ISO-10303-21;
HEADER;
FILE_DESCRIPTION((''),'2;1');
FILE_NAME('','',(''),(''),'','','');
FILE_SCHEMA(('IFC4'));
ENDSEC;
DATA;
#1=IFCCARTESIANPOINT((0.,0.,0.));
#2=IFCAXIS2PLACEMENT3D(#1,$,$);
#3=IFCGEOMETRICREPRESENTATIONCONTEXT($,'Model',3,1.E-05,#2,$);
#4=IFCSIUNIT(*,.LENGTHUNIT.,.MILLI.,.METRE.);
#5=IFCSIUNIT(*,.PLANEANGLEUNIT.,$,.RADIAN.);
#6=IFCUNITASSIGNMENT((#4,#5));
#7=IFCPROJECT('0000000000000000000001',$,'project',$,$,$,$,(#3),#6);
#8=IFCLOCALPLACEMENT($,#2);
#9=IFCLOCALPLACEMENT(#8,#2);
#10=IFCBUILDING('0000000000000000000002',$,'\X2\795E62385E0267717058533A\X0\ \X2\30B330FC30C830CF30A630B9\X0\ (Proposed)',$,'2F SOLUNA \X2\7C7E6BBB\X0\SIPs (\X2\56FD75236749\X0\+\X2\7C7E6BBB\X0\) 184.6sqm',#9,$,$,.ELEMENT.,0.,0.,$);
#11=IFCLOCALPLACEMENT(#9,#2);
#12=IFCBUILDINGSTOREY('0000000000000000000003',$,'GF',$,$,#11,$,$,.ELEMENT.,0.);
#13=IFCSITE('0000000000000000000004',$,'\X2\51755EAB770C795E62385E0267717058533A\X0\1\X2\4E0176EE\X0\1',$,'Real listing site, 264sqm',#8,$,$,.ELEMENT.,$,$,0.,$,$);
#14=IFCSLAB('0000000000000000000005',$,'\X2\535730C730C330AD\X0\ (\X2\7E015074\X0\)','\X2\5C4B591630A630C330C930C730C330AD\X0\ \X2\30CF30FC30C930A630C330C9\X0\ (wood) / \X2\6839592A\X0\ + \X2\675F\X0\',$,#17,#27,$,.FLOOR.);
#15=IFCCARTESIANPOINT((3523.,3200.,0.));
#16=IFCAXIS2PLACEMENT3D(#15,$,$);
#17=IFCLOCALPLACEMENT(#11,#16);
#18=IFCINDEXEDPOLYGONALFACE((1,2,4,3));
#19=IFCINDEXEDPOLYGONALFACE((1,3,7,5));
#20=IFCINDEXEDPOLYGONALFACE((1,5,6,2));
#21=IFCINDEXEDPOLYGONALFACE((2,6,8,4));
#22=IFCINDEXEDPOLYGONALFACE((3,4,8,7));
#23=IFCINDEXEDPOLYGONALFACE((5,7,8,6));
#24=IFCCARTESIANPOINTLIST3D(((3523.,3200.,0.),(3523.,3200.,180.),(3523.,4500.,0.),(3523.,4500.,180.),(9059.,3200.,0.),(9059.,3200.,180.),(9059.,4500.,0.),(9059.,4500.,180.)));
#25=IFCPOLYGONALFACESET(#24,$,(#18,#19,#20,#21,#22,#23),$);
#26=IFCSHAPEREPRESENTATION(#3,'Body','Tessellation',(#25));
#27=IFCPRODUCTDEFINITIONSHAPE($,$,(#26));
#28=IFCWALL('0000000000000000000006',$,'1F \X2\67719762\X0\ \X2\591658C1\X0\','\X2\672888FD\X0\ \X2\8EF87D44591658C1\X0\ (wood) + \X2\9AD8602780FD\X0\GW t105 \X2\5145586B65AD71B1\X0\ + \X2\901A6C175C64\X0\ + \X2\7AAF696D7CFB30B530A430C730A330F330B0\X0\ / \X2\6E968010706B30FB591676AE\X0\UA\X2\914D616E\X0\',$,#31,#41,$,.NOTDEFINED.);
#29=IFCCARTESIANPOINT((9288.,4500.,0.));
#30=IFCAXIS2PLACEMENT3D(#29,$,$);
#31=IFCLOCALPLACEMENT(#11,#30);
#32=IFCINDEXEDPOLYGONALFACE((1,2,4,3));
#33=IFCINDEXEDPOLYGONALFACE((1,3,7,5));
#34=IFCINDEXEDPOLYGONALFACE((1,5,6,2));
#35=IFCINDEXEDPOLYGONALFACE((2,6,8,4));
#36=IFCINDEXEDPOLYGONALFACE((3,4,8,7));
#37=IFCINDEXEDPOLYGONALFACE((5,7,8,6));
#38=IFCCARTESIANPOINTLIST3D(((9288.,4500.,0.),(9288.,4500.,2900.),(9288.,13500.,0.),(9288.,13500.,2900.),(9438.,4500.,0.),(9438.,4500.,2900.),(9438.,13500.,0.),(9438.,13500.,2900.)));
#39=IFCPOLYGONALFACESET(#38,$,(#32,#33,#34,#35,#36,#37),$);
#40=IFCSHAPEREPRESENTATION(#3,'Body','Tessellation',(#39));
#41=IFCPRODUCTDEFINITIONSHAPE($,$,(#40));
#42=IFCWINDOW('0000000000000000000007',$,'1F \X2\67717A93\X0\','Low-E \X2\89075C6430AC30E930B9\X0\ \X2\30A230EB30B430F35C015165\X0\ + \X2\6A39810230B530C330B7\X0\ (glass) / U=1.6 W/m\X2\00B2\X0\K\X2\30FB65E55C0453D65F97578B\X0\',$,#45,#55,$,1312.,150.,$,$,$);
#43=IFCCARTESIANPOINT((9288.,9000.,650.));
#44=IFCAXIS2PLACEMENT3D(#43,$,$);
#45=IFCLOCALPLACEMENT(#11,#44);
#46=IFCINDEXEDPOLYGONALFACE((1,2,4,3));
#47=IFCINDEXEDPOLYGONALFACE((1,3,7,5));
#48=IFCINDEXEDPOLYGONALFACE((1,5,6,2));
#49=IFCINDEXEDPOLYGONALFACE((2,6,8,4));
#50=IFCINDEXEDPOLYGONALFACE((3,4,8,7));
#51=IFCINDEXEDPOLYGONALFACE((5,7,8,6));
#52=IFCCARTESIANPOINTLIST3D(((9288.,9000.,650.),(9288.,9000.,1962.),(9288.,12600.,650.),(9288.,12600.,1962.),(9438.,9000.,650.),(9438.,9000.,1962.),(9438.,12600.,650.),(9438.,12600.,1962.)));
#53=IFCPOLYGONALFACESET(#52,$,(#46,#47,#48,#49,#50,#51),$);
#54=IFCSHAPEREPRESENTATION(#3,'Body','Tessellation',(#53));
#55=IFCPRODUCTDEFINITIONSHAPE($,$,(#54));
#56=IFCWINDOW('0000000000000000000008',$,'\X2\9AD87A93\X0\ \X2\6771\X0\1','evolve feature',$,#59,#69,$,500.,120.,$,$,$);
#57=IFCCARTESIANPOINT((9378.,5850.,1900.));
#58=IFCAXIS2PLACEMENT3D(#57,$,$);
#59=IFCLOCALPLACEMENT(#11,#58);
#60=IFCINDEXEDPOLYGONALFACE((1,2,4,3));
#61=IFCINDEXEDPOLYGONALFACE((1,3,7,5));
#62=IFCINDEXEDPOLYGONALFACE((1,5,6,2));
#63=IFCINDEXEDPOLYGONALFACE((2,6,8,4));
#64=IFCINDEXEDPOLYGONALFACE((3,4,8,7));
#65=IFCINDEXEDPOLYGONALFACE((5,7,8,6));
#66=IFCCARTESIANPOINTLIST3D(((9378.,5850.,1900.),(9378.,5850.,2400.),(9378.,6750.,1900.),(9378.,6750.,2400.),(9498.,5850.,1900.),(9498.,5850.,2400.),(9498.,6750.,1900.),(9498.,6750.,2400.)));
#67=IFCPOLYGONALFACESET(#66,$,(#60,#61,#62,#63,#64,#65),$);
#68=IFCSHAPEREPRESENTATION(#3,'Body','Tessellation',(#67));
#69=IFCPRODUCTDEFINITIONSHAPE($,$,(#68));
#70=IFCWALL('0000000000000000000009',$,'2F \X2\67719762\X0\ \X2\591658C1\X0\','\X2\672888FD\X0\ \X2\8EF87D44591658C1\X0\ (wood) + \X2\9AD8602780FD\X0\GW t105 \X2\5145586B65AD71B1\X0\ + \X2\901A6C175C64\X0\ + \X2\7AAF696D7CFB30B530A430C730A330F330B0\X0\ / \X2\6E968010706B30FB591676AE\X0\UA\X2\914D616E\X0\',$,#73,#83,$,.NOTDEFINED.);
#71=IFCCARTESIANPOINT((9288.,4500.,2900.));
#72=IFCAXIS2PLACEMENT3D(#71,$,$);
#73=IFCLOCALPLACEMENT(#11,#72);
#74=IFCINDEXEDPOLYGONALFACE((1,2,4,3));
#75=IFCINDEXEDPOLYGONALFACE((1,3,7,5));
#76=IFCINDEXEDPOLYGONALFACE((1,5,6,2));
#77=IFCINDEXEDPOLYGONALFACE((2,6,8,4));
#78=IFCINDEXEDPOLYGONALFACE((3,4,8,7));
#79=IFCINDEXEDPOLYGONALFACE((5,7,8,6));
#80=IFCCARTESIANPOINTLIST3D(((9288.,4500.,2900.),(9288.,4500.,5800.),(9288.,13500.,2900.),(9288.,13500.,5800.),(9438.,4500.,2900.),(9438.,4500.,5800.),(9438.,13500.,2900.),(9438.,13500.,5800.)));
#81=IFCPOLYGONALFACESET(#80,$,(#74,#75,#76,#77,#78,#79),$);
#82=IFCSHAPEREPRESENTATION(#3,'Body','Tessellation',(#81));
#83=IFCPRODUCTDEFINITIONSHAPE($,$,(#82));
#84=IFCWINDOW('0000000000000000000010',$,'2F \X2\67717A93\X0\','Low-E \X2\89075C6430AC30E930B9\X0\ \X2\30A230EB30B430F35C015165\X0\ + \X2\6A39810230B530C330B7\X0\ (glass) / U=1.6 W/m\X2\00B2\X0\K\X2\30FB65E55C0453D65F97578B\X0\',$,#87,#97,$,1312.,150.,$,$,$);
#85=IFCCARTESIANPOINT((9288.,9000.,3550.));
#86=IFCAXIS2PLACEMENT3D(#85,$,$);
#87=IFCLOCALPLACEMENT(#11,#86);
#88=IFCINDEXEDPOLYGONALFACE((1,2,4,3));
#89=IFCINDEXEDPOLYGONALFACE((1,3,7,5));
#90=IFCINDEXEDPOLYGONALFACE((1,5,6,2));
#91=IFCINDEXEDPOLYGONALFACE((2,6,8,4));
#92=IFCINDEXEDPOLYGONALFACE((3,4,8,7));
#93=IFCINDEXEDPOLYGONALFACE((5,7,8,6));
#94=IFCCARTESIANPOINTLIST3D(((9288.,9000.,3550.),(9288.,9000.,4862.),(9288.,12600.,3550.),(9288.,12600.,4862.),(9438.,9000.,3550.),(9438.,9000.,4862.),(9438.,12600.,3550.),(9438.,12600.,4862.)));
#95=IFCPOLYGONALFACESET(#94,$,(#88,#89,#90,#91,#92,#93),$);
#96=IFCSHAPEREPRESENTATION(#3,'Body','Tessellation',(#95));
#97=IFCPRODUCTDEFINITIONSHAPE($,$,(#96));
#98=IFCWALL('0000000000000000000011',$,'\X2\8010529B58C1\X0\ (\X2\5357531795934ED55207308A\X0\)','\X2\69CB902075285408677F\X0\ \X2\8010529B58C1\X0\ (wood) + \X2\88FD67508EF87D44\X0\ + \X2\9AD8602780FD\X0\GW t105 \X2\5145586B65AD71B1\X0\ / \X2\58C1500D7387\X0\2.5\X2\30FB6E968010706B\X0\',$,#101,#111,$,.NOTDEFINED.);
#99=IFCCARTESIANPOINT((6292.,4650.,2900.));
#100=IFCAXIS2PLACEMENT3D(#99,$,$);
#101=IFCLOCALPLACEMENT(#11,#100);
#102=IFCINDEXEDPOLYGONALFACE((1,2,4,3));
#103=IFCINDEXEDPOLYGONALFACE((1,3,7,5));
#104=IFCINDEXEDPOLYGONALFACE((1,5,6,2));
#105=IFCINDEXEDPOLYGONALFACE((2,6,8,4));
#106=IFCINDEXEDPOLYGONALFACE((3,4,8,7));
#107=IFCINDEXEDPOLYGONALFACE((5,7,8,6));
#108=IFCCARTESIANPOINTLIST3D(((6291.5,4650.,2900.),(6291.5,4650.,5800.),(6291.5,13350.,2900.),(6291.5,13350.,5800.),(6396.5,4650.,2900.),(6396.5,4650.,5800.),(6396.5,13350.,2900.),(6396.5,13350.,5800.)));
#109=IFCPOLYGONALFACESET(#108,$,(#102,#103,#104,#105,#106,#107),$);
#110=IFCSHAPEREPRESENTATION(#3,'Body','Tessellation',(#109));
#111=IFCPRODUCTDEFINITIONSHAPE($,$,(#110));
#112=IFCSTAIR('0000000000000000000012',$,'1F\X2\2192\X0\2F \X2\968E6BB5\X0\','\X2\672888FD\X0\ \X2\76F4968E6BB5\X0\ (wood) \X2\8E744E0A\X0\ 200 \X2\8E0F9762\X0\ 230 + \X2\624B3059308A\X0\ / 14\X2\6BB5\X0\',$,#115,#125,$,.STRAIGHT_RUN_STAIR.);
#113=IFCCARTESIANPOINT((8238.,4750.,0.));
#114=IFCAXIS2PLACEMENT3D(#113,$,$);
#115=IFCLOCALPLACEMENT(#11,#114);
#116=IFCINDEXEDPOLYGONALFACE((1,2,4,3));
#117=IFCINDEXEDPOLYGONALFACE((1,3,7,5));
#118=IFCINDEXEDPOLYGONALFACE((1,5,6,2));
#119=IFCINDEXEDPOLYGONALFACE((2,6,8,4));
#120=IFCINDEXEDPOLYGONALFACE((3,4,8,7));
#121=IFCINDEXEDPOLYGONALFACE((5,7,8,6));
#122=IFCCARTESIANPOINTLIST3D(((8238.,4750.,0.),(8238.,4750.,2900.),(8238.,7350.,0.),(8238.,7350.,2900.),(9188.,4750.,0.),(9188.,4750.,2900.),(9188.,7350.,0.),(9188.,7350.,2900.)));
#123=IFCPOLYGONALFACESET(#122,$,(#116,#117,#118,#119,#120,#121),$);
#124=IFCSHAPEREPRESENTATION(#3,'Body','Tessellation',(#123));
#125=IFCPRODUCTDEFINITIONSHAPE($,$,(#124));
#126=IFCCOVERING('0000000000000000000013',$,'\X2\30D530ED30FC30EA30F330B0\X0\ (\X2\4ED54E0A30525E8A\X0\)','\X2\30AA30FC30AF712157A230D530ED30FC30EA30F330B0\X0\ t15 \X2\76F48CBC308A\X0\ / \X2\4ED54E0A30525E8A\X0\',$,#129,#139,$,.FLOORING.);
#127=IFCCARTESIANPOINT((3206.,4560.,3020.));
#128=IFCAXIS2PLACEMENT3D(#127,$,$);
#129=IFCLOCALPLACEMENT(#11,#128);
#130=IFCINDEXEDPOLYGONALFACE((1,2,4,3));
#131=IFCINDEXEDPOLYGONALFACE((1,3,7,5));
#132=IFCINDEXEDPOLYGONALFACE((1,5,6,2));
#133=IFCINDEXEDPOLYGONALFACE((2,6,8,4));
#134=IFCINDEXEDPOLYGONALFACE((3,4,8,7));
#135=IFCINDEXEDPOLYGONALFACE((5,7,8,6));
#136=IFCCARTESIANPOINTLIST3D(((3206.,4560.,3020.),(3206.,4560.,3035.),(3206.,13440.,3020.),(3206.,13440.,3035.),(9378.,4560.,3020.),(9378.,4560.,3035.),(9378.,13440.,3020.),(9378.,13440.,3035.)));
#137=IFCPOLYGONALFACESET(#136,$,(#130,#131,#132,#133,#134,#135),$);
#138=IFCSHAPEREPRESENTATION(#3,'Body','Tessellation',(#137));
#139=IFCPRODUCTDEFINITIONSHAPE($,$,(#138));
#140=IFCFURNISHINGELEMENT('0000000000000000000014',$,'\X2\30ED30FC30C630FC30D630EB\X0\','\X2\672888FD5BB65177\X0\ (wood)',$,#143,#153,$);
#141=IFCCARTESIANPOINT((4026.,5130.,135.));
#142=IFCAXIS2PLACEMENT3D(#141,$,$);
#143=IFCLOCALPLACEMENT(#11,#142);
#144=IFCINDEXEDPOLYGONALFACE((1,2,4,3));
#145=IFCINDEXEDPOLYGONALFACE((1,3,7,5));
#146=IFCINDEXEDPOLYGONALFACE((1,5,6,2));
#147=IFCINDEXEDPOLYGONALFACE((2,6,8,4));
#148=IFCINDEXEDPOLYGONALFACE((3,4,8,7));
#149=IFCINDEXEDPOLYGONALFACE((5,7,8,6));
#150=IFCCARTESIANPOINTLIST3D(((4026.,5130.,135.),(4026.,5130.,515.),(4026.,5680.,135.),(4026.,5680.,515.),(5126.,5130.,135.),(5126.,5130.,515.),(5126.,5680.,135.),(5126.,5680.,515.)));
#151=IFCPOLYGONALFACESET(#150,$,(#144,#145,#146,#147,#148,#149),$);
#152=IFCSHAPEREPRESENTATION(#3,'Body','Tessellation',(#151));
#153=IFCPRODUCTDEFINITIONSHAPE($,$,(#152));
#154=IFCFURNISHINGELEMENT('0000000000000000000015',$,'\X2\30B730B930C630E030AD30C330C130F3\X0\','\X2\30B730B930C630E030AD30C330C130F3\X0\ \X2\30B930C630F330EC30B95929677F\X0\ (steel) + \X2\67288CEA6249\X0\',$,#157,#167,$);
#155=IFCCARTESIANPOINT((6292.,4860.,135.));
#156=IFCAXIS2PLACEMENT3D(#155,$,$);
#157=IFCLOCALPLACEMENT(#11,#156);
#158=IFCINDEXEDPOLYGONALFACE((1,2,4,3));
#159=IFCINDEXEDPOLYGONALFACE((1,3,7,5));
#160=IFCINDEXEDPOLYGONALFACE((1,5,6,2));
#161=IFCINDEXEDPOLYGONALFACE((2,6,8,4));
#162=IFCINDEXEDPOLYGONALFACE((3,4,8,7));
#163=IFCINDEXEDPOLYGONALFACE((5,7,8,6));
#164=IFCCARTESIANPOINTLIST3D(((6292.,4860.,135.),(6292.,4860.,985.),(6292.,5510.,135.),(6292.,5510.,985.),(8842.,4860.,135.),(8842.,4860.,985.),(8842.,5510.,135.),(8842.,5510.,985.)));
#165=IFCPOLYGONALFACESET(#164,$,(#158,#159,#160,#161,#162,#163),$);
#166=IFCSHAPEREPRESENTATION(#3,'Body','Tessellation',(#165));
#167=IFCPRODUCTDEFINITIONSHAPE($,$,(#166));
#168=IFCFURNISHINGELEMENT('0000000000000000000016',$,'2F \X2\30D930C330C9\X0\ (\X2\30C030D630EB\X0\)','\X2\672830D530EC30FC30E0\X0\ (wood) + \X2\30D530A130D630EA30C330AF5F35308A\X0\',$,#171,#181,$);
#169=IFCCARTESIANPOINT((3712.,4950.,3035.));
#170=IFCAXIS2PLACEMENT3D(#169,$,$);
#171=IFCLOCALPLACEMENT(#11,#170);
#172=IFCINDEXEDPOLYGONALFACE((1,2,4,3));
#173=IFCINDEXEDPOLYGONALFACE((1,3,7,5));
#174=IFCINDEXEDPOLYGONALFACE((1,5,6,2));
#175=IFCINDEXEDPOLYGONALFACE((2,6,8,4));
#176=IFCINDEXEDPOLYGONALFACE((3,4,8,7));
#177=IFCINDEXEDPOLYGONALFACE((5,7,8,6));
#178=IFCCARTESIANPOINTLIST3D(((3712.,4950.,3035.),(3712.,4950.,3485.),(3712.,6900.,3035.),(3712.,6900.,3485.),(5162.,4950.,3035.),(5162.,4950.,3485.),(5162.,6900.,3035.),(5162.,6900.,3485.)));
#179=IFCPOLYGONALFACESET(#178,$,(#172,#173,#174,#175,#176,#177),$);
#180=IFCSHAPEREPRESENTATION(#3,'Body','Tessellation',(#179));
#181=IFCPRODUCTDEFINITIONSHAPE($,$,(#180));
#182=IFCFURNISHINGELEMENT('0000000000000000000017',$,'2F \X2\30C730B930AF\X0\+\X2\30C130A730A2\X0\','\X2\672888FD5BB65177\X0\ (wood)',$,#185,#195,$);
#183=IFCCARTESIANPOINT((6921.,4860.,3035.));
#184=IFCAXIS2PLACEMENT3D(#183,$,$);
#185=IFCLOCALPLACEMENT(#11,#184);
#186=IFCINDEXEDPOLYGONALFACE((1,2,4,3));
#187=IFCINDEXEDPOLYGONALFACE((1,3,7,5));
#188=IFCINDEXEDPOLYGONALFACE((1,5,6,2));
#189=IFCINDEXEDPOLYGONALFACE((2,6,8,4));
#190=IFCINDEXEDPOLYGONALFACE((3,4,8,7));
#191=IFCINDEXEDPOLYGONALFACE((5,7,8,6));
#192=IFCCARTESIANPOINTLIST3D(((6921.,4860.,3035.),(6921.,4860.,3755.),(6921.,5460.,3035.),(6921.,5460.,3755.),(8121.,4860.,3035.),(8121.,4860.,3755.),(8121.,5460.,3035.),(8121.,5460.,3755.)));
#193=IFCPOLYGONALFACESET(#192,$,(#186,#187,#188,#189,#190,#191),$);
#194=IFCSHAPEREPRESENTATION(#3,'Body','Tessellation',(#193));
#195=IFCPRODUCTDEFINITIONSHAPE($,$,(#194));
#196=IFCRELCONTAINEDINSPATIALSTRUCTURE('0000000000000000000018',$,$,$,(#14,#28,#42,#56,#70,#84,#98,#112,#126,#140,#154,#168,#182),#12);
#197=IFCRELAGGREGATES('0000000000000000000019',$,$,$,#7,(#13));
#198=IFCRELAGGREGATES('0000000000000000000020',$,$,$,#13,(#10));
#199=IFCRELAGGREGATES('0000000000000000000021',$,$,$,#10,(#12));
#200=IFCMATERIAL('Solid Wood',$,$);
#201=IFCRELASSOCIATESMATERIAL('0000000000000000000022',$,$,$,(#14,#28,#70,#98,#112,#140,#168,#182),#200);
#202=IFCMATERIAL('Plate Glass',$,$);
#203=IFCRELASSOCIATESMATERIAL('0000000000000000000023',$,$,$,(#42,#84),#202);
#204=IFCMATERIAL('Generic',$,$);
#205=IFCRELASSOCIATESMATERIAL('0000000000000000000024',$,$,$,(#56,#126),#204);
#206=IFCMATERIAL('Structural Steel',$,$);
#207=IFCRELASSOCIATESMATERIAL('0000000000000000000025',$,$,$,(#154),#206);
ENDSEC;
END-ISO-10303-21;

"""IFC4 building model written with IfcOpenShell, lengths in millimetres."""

from ifc_helpers import new_model, si_unit, frame, frame_2d, origin, place, context, project, spatial, rectangle, extrude, material, element, fill, save


model = new_model("IFC4")

# Units and contexts
model_context = context("Model", 3, precision=1e-05, world=origin())
ifc_project = project(units=[si_unit("LENGTHUNIT", "METRE", prefix="MILLI"), si_unit("PLANEANGLEUNIT", "RADIAN")], contexts=[model_context])

# Site, building, storey
site_placement = place(None, origin())
site = spatial("IfcSite", under=ifc_project, at=site_placement, Name="兵庫県神戸市東灘区1丁目1", ObjectType="Real listing site, 264sqm", CompositionType="ELEMENT", RefElevation=0.0)
building_placement = place(site_placement, origin())
building = spatial("IfcBuilding", under=site, at=building_placement, Name="神戸市東灘区 コートハウス (Proposed)", ObjectType="2F SOLUNA 籾殻SIPs (国産杉+籾殻) 184.6sqm", CompositionType="ELEMENT", ElevationOfRefHeight=0.0, ElevationOfTerrain=0.0)
storey_placement = place(building_placement, origin())
storey = spatial("IfcBuildingStorey", under=building, at=storey_placement, Name="GF", CompositionType="ELEMENT", Elevation=0.0)

# Slab
ifc_material_1 = material(Name="Solid Wood")
slab_placement = place(storey_placement, frame((3523.0, 3200.0, 0.0)))
element("IfcSlab", 1, at=slab_placement, inside=storey, material=ifc_material_1, Name="南デッキ (縁側)", Description="屋外ウッドデッキ ハードウッド (wood) / 根太 + 束", PredefinedType="FLOOR", context=model_context, shape_type="SweptSolid", body=[
    extrude(rectangle(XDim=5536.0, YDim=1300.0, at=frame_2d((2768.0, 650.0))), frame((3523.0, 3200.0, 0.0)), (0.0, 0.0, 1.0), 180.0),
])

# Wall, openings, windows
wall_1_placement = place(storey_placement, frame((9288.0, 4500.0, 0.0)))
wall_1 = element("IfcWall", 2, at=wall_1_placement, inside=storey, material=ifc_material_1, Name="1F 東面 外壁", Description="木製 軸組外壁 (wood) + 高性能GW t105 充填断熱 + 通気層 + 窯業系サイディング / 準耐火・外皮UA配慮", PredefinedType="NOTDEFINED", context=model_context, shape_type="SweptSolid", body=[
    extrude(rectangle(XDim=150.0, YDim=9000.0, at=frame_2d((75.0, 4500.0))), frame((9288.0, 4500.0, 0.0)), (0.0, 0.0, 1.0), 2900.0),
])
opening_1_placement = place(storey_placement, frame((9288.0, 9000.0, 650.0)))
opening_1 = element("IfcOpeningElement", 3, at=opening_1_placement, cuts=wall_1, PredefinedType="NOTDEFINED", context=model_context, shape_type="SweptSolid", body=[
    extrude(rectangle(XDim=150.0, YDim=3600.0, at=frame_2d((75.0, 1800.0))), frame((9288.0, 9000.0, 650.0)), (0.0, 0.0, 1.0), 1312.0),
])
opening_2_placement = place(storey_placement, frame((9378.0, 5850.0, 1900.0)))
opening_2 = element("IfcOpeningElement", 4, at=opening_2_placement, cuts=wall_1, PredefinedType="NOTDEFINED", context=model_context, shape_type="SweptSolid", body=[
    extrude(rectangle(XDim=120.0, YDim=900.0, at=frame_2d((60.0, 450.0))), frame((9378.0, 5850.0, 1900.0)), (0.0, 0.0, 1.0), 500.0),
])
ifc_material_2 = material(Name="Plate Glass")
window_1_placement = place(storey_placement, frame((9288.0, 9000.0, 650.0)))
window_1 = element("IfcWindow", 5, at=window_1_placement, inside=storey, material=ifc_material_2, Name="1F 東窓", Description="Low-E 複層ガラス アルゴン封入 + 樹脂サッシ (glass) / U=1.6 W/m²K・日射取得型", OverallHeight=1312.0, OverallWidth=150.0, context=model_context, shape_type="SweptSolid", body=[
    extrude(rectangle(XDim=150.0, YDim=3600.0, at=frame_2d((75.0, 1800.0))), frame((9288.0, 9000.0, 650.0)), (0.0, 0.0, 1.0), 1312.0),
])
fill(opening_1, window_1)
ifc_material_3 = material(Name="Generic")
window_2_placement = place(storey_placement, frame((9378.0, 5850.0, 1900.0)))
window_2 = element("IfcWindow", 6, at=window_2_placement, inside=storey, material=ifc_material_3, Name="高窓 東1", Description="evolve feature", OverallHeight=500.0, OverallWidth=120.0, context=model_context, shape_type="SweptSolid", body=[
    extrude(rectangle(XDim=120.0, YDim=900.0, at=frame_2d((60.0, 450.0))), frame((9378.0, 5850.0, 1900.0)), (0.0, 0.0, 1.0), 500.0),
])
fill(opening_2, window_2)

# Wall, opening, window
wall_2_placement = place(storey_placement, frame((9288.0, 4500.0, 2900.0)))
wall_2 = element("IfcWall", 7, at=wall_2_placement, inside=storey, material=ifc_material_1, Name="2F 東面 外壁", Description="木製 軸組外壁 (wood) + 高性能GW t105 充填断熱 + 通気層 + 窯業系サイディング / 準耐火・外皮UA配慮", PredefinedType="NOTDEFINED", context=model_context, shape_type="SweptSolid", body=[
    extrude(rectangle(XDim=150.0, YDim=9000.0, at=frame_2d((75.0, 4500.0))), frame((9288.0, 4500.0, 2900.0)), (0.0, 0.0, 1.0), 2900.0),
])
opening_3_placement = place(storey_placement, frame((9288.0, 9000.0, 3550.0)))
opening_3 = element("IfcOpeningElement", 8, at=opening_3_placement, cuts=wall_2, PredefinedType="NOTDEFINED", context=model_context, shape_type="SweptSolid", body=[
    extrude(rectangle(XDim=150.0, YDim=3600.0, at=frame_2d((75.0, 1800.0))), frame((9288.0, 9000.0, 3550.0)), (0.0, 0.0, 1.0), 1312.0),
])
window_3_placement = place(storey_placement, frame((9288.0, 9000.0, 3550.0)))
window_3 = element("IfcWindow", 9, at=window_3_placement, inside=storey, material=ifc_material_2, Name="2F 東窓", Description="Low-E 複層ガラス アルゴン封入 + 樹脂サッシ (glass) / U=1.6 W/m²K・日射取得型", OverallHeight=1312.0, OverallWidth=150.0, context=model_context, shape_type="SweptSolid", body=[
    extrude(rectangle(XDim=150.0, YDim=3600.0, at=frame_2d((75.0, 1800.0))), frame((9288.0, 9000.0, 3550.0)), (0.0, 0.0, 1.0), 1312.0),
])
fill(opening_3, window_3)

# Wall
wall_3_placement = place(storey_placement, frame((6292.0, 4650.0, 2900.0)))
element("IfcWall", 10, at=wall_3_placement, inside=storey, material=ifc_material_1, Name="耐力壁 (南北間仕切り)", Description="構造用合板 耐力壁 (wood) + 製材軸組 + 高性能GW t105 充填断熱 / 壁倍率2.5・準耐火", PredefinedType="NOTDEFINED", context=model_context, shape_type="SweptSolid", body=[
    extrude(rectangle(XDim=105.0, YDim=8700.0, at=frame_2d((52.0, 4350.0))), frame((6292.0, 4650.0, 2900.0)), (0.0, 0.0, 1.0), 2900.0),
])

# Stair
stair_placement = place(storey_placement, frame((8238.0, 4750.0, 0.0)))
element("IfcStair", 11, at=stair_placement, inside=storey, material=ifc_material_1, Name="1F→2F 階段", Description="木製 直階段 (wood) 蹴上 200 踏面 230 + 手すり / 14段", PredefinedType="STRAIGHT_RUN_STAIR", context=model_context, shape_type="SweptSolid", body=[
    extrude(rectangle(XDim=950.0, YDim=2600.0, at=frame_2d((475.0, 1300.0))), frame((8238.0, 4750.0, 0.0)), (0.0, 0.0, 1.0), 2900.0),
])

# Covering
covering_placement = place(storey_placement, frame((3206.0, 4560.0, 3020.0)))
element("IfcCovering", 12, at=covering_placement, inside=storey, material=ifc_material_3, Name="フローリング (仕上げ床)", Description="オーク無垢フローリング t15 直貼り / 仕上げ床", PredefinedType="FLOORING", context=model_context, shape_type="SweptSolid", body=[
    extrude(rectangle(XDim=6172.0, YDim=8880.0, at=frame_2d((3086.0, 4440.0))), frame((3206.0, 4560.0, 3020.0)), (0.0, 0.0, 1.0), 15.0),
])

# Furnishing elements
furnishing_1_placement = place(storey_placement, frame((4026.0, 5130.0, 135.0)))
element("IfcFurnishingElement", 13, at=furnishing_1_placement, inside=storey, material=ifc_material_1, Name="ローテーブル", Description="木製家具 (wood)", context=model_context, shape_type="SweptSolid", body=[
    extrude(rectangle(XDim=1100.0, YDim=550.0, at=frame_2d((550.0, 275.0))), frame((4026.0, 5130.0, 135.0)), (0.0, 0.0, 1.0), 380.0),
])
ifc_material_4 = material(Name="Structural Steel")
furnishing_2_placement = place(storey_placement, frame((6292.0, 4860.0, 135.0)))
element("IfcFurnishingElement", 14, at=furnishing_2_placement, inside=storey, material=ifc_material_4, Name="システムキッチン", Description="システムキッチン ステンレス天板 (steel) + 木質扉", context=model_context, shape_type="SweptSolid", body=[
    extrude(rectangle(XDim=2550.0, YDim=650.0, at=frame_2d((1275.0, 325.0))), frame((6292.0, 4860.0, 135.0)), (0.0, 0.0, 1.0), 850.0),
])
furnishing_3_placement = place(storey_placement, frame((3712.0, 4950.0, 3035.0)))
element("IfcFurnishingElement", 15, at=furnishing_3_placement, inside=storey, material=ifc_material_1, Name="2F ベッド (ダブル)", Description="木フレーム (wood) + ファブリック張り", context=model_context, shape_type="SweptSolid", body=[
    extrude(rectangle(XDim=1450.0, YDim=1950.0, at=frame_2d((725.0, 975.0))), frame((3712.0, 4950.0, 3035.0)), (0.0, 0.0, 1.0), 450.0),
])
furnishing_4_placement = place(storey_placement, frame((6921.0, 4860.0, 3035.0)))
element("IfcFurnishingElement", 16, at=furnishing_4_placement, inside=storey, material=ifc_material_1, Name="2F デスク+チェア", Description="木製家具 (wood)", context=model_context, shape_type="SweptSolid", body=[
    extrude(rectangle(XDim=1200.0, YDim=600.0, at=frame_2d((600.0, 300.0))), frame((6921.0, 4860.0, 3035.0)), (0.0, 0.0, 1.0), 720.0),
])

save(model, "model.ifc")
